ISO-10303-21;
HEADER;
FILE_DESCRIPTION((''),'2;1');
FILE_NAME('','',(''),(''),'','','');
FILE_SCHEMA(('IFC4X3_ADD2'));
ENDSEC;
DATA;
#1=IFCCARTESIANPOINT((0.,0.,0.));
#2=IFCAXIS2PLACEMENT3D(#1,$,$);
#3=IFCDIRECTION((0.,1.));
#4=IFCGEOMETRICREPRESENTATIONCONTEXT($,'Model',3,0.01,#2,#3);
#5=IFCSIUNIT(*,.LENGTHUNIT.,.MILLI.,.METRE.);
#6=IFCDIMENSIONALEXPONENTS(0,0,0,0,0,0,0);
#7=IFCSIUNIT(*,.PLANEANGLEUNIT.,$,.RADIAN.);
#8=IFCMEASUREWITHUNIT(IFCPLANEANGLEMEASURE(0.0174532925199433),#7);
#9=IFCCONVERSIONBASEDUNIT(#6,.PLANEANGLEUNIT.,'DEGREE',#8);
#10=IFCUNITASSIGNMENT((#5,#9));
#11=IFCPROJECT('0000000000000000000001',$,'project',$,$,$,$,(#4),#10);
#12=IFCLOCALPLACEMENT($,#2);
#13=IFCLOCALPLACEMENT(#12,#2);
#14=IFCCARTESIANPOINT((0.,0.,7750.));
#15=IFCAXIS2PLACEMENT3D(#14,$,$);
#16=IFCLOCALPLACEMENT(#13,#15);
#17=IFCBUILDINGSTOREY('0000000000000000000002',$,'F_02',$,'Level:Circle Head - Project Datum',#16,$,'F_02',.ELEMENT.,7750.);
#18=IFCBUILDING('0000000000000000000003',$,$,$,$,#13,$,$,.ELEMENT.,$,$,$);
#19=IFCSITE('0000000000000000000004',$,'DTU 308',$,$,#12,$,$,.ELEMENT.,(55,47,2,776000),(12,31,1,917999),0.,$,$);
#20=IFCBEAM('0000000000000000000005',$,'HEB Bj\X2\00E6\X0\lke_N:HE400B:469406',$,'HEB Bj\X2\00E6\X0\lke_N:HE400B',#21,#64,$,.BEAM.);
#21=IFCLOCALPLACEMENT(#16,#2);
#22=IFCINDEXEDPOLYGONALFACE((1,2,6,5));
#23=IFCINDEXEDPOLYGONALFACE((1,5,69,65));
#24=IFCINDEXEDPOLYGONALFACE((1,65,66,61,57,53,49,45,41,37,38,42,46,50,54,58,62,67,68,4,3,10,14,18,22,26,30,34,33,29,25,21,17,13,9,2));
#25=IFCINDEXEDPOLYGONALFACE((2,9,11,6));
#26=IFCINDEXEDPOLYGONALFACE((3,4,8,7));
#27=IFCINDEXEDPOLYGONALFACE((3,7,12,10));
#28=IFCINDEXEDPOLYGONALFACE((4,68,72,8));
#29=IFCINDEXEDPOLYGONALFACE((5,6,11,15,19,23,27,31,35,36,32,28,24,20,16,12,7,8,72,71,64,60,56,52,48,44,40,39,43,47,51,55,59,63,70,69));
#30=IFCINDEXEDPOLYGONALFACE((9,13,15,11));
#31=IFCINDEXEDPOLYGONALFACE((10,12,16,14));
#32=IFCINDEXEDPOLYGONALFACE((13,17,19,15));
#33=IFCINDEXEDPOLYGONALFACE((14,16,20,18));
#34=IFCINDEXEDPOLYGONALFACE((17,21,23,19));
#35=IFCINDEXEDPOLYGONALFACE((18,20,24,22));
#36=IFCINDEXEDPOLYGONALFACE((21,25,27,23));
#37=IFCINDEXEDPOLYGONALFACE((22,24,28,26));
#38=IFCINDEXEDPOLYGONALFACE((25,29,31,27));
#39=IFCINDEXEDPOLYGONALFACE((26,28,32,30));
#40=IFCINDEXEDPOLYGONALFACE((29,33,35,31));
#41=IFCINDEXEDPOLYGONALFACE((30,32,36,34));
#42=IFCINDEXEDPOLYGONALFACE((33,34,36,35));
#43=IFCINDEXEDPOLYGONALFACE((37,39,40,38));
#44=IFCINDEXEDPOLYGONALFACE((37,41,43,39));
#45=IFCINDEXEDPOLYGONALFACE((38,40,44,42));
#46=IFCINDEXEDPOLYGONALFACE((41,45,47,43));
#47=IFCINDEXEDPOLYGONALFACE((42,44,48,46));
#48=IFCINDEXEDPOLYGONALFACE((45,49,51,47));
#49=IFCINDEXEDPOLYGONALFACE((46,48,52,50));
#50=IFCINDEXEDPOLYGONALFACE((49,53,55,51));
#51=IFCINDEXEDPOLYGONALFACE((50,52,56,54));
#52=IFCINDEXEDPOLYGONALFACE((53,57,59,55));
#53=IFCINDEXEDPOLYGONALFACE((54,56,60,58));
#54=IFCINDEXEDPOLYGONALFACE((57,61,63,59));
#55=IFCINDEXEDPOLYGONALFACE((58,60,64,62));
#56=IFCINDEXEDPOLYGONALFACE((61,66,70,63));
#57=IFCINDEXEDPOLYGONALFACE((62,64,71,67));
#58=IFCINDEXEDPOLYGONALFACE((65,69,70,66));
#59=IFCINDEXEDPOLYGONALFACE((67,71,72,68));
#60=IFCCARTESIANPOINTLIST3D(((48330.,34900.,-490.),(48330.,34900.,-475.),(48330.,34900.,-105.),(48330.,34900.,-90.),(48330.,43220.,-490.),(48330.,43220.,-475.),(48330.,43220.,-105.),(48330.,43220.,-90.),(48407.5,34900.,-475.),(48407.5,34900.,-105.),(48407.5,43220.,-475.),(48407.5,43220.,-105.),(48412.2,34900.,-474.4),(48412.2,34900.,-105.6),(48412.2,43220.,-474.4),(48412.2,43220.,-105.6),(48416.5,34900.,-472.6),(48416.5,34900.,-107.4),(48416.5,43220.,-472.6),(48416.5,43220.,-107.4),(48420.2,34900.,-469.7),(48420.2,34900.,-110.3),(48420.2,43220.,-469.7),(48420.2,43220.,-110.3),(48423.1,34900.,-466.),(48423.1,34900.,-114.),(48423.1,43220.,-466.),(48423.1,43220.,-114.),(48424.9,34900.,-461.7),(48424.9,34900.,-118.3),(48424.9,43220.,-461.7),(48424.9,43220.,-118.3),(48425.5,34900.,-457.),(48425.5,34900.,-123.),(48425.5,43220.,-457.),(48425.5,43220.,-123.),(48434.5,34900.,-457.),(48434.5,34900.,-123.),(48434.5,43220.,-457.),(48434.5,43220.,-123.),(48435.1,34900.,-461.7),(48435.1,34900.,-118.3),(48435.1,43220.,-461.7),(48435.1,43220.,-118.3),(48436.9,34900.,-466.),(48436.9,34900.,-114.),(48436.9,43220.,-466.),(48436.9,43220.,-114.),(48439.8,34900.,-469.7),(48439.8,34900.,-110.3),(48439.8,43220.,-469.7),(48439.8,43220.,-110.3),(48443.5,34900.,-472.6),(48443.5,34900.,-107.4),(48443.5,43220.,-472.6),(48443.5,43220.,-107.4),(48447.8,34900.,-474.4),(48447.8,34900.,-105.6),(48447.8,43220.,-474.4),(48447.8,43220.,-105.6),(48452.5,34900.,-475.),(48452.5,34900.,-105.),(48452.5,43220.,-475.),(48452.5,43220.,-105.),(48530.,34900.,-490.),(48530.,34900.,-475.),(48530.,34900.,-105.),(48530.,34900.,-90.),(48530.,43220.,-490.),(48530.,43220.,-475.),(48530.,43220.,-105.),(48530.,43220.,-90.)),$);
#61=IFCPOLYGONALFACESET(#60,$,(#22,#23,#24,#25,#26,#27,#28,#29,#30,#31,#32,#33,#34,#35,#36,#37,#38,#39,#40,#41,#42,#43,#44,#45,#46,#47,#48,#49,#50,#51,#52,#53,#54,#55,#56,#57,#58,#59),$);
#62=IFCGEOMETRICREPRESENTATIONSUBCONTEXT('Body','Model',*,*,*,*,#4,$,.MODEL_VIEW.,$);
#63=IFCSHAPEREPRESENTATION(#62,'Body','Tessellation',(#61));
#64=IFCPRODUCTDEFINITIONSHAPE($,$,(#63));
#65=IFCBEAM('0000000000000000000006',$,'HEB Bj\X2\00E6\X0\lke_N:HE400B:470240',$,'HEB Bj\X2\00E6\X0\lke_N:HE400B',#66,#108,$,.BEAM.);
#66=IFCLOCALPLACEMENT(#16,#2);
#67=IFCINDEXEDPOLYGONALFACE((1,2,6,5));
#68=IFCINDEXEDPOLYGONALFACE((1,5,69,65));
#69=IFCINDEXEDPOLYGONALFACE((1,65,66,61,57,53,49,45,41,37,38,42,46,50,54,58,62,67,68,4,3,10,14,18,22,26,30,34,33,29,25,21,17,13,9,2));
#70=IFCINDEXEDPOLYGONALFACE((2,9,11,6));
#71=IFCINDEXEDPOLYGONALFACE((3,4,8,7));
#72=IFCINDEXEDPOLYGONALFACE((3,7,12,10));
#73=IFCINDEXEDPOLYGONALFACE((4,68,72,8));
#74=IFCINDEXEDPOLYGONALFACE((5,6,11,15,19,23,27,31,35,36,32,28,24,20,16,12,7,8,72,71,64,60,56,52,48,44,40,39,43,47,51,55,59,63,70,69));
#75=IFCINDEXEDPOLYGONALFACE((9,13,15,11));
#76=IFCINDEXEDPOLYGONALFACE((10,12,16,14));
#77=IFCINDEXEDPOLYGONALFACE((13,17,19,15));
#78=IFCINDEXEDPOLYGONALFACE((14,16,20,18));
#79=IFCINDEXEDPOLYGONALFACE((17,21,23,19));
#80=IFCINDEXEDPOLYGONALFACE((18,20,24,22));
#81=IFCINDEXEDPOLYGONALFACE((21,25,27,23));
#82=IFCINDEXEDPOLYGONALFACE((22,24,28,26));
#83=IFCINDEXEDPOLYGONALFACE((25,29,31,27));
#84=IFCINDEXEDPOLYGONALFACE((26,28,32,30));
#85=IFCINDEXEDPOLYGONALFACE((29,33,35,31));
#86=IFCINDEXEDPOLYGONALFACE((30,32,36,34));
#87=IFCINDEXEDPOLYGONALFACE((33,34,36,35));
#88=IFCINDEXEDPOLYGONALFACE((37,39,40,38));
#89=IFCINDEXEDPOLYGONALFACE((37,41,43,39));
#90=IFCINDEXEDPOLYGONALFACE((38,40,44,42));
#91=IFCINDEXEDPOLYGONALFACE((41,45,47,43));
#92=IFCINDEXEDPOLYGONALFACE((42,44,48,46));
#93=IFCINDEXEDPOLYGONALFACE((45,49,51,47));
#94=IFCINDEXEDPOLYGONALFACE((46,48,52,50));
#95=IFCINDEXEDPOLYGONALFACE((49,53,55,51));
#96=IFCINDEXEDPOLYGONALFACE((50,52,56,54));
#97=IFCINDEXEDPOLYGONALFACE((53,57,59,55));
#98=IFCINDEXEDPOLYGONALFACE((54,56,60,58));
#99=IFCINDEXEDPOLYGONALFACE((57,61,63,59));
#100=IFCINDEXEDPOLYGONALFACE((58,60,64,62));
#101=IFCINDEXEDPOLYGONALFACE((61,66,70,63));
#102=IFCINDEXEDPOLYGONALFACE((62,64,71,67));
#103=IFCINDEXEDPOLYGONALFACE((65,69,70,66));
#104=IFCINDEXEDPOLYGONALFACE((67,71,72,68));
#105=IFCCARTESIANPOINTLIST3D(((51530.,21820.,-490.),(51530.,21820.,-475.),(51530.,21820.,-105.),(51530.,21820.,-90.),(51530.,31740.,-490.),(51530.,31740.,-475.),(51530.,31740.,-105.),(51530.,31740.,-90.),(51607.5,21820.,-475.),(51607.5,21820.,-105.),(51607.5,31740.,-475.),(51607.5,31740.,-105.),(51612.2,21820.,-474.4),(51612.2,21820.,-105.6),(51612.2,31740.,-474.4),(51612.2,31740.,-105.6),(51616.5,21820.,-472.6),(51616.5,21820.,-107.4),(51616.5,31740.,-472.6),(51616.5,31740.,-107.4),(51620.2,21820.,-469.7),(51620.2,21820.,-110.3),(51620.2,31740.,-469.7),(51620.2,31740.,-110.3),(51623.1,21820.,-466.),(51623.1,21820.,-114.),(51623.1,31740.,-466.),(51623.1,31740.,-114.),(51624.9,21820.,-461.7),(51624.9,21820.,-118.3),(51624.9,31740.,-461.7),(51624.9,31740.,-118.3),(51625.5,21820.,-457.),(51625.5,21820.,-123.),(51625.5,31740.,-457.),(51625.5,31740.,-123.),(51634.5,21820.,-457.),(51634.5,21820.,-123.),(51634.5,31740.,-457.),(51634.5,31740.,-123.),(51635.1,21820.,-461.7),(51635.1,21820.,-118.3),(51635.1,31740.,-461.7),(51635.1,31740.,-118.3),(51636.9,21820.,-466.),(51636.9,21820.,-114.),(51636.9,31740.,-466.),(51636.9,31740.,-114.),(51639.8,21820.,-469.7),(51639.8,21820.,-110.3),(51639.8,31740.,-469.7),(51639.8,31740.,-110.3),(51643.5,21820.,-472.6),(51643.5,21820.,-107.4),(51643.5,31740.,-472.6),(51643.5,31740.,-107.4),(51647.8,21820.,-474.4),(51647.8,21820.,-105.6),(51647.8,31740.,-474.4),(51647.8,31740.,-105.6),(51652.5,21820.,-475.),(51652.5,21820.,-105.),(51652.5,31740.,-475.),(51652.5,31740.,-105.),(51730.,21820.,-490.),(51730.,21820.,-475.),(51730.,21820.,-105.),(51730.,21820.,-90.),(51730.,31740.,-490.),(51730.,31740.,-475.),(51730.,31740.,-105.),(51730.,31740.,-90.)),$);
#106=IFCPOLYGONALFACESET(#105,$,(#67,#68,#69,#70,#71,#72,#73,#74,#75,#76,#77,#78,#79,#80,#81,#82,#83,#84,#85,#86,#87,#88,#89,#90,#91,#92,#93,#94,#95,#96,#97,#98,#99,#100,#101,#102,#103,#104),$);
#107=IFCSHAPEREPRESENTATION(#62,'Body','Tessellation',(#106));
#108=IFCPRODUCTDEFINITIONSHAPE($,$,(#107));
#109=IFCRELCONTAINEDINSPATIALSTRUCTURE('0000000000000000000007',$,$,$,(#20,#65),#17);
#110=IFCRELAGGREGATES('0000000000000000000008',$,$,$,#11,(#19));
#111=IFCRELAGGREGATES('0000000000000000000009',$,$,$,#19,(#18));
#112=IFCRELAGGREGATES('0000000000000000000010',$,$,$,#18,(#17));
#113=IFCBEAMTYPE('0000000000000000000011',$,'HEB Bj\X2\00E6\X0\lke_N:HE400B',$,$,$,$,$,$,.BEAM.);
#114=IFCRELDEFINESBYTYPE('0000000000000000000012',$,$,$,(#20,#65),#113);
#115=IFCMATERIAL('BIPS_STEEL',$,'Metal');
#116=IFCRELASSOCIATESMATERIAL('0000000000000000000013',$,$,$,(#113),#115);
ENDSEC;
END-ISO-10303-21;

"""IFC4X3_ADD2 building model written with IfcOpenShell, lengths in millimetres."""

from ifc_helpers import new_model, entity, si_unit, converted_unit, direction, frame, frame_2d, origin, place, context, subcontext, project, spatial, polyline, circle_curve, parameter, trimmed, segment, composite_curve, outline, extrude, source, transform, mapped, material, material_profile, profile_set, type_object, element, save


model = new_model("IFC4X3_ADD2")

# Units and contexts
model_context = context("Model", 3, precision=0.01, world=origin(), true_north=direction((0.0, 1.0)))
body_context = subcontext(model_context, "Body", "Model", "MODEL_VIEW")
ifc_project = project(units=[si_unit("LENGTHUNIT", "METRE", prefix="MILLI"), converted_unit("PLANEANGLEUNIT", "DEGREE", entity("IfcPlaneAngleMeasure", 0.0174532925199433), si_unit("PLANEANGLEUNIT", "RADIAN"), dimensions=[0, 0, 0, 0, 0, 0, 0])], contexts=[model_context])

# Site, building, storey
site_placement = place(None, origin())
site = spatial("IfcSite", under=ifc_project, at=site_placement, Name="DTU 308", CompositionType="ELEMENT", RefLatitude=(55, 47, 2, 776000), RefLongitude=(12, 31, 1, 917999), RefElevation=0.0)
building_placement = place(site_placement, origin())
building = spatial("IfcBuilding", under=site, at=building_placement, CompositionType="ELEMENT")
storey_placement = place(building_placement, frame((0.0, 0.0, 7750.0)))
storey = spatial("IfcBuildingStorey", under=building, at=storey_placement, Name="F_02", ObjectType="Level:Circle Head - Project Datum", LongName="F_02", CompositionType="ELEMENT", Elevation=7750.0)

# Shared definitions
ifc_material = material(Name="BIPS_STEEL", Category="Metal")

# Beams
ifc_material_profile_1 = material_profile(ifc_material, outline(composite_curve([segment(polyline([(-100.0, -185.0), (-100.0, -200.0)]), True, "CONTINUOUS"), segment(polyline([(-100.0, -200.0), (100.0, -200.0)]), True, "CONTINUOUS"), segment(polyline([(100.0, -200.0), (100.0, -185.0)]), True, "CONTINUOUS"), segment(polyline([(100.0, -185.0), (22.5, -185.0)]), True, "CONTINUOUS"), segment(trimmed(circle_curve(frame_2d((22.5, -167.0), x_axis=(1.0, 0.0)), 18.0), [parameter(180.0)], [parameter(270.0)], True, "PARAMETER"), False, "CONTINUOUS"), segment(polyline([(4.5, -167.0), (4.5, 167.0)]), True, "CONTINUOUS"), segment(trimmed(circle_curve(frame_2d((22.5, 167.0), x_axis=(1.0, 0.0)), 18.0), [parameter(90.0)], [parameter(180.0)], True, "PARAMETER"), False, "CONTINUOUS"), segment(polyline([(22.5, 185.0), (100.0, 185.0)]), True, "CONTINUOUS"), segment(polyline([(100.0, 185.0), (100.0, 200.0)]), True, "CONTINUOUS"), segment(polyline([(100.0, 200.0), (-100.0, 200.0)]), True, "CONTINUOUS"), segment(polyline([(-100.0, 200.0), (-100.0, 185.0)]), True, "CONTINUOUS"), segment(polyline([(-100.0, 185.0), (-22.5, 185.0)]), True, "CONTINUOUS"), segment(trimmed(circle_curve(frame_2d((-22.5, 167.0), x_axis=(1.0, 0.0)), 18.0), [parameter(360.0)], [parameter(90.0)], True, "PARAMETER"), False, "CONTINUOUS"), segment(polyline([(-4.5, 167.0), (-4.5, -167.0)]), True, "CONTINUOUS"), segment(trimmed(circle_curve(frame_2d((-22.5, -167.0), x_axis=(1.0, 0.0)), 18.0), [parameter(270.0)], [parameter(360.0)], True, "PARAMETER"), False, "CONTINUOUS"), segment(polyline([(-22.5, -185.0), (-100.0, -185.0)]), True, "CONTINUOUS")], self_intersect=False)), Name="HE400B")
ifc_profile_set_1 = profile_set([ifc_material_profile_1], Name="HE400B")
beam_type_1 = type_object("IfcBeamType", Name="HEB Bjælke_N:HE400B", PredefinedType="BEAM", material=ifc_profile_set_1)
shared_shape_1 = source(origin(), body_context, "Body", "SweptSolid", [
    extrude(outline(composite_curve([segment(polyline([(-100.0, -185.0), (-100.0, -200.0)]), True, "CONTINUOUS"), segment(polyline([(-100.0, -200.0), (100.0, -200.0)]), True, "CONTINUOUS"), segment(polyline([(100.0, -200.0), (100.0, -185.0)]), True, "CONTINUOUS"), segment(polyline([(100.0, -185.0), (22.5, -185.0)]), True, "CONTINUOUS"), segment(trimmed(circle_curve(frame_2d((22.5, -167.0), x_axis=(1.0, 0.0)), 18.0), [parameter(180.0)], [parameter(270.0)], True, "PARAMETER"), False, "CONTINUOUS"), segment(polyline([(4.5, -167.0), (4.5, 167.0)]), True, "CONTINUOUS"), segment(trimmed(circle_curve(frame_2d((22.5, 167.0), x_axis=(1.0, 0.0)), 18.0), [parameter(90.0)], [parameter(180.0)], True, "PARAMETER"), False, "CONTINUOUS"), segment(polyline([(22.5, 185.0), (100.0, 185.0)]), True, "CONTINUOUS"), segment(polyline([(100.0, 185.0), (100.0, 200.0)]), True, "CONTINUOUS"), segment(polyline([(100.0, 200.0), (-100.0, 200.0)]), True, "CONTINUOUS"), segment(polyline([(-100.0, 200.0), (-100.0, 185.0)]), True, "CONTINUOUS"), segment(polyline([(-100.0, 185.0), (-22.5, 185.0)]), True, "CONTINUOUS"), segment(trimmed(circle_curve(frame_2d((-22.5, 167.0), x_axis=(1.0, 0.0)), 18.0), [parameter(360.0)], [parameter(90.0)], True, "PARAMETER"), False, "CONTINUOUS"), segment(polyline([(-4.5, 167.0), (-4.5, -167.0)]), True, "CONTINUOUS"), segment(trimmed(circle_curve(frame_2d((-22.5, -167.0), x_axis=(1.0, 0.0)), 18.0), [parameter(270.0)], [parameter(360.0)], True, "PARAMETER"), False, "CONTINUOUS"), segment(polyline([(-22.5, -185.0), (-100.0, -185.0)]), True, "CONTINUOUS")], self_intersect=False)), frame((-6461.4, 0.0, 0.0), z_axis=(-1.0, 0.0, 0.0), x_axis=(0.0, -1.0, 0.0)), (0.0, 0.0, -1.0), 8320.0),
])
beam_1_placement = place(storey_placement, frame((48430.0, 36758.6, -290.0), z_axis=(0.0, 0.0, 1.0), x_axis=(0.0, -1.0, 0.0)))
element("IfcBeam", 1, at=beam_1_placement, inside=storey, type_object=beam_type_1, Name="HEB Bjælke_N:HE400B:469406", ObjectType="HEB Bjælke_N:HE400B", PredefinedType="BEAM", context=body_context, shape_type="MappedRepresentation", body=[
    mapped(shared_shape_1, transform((0.0, 0.0, 0.0), scale=1.0)),
])
shared_shape_2 = source(origin(), body_context, "Body", "SweptSolid", [
    extrude(outline(composite_curve([segment(polyline([(-100.0, -185.0), (-100.0, -200.0)]), True, "CONTINUOUS"), segment(polyline([(-100.0, -200.0), (100.0, -200.0)]), True, "CONTINUOUS"), segment(polyline([(100.0, -200.0), (100.0, -185.0)]), True, "CONTINUOUS"), segment(polyline([(100.0, -185.0), (22.5, -185.0)]), True, "CONTINUOUS"), segment(trimmed(circle_curve(frame_2d((22.5, -167.0), x_axis=(1.0, 0.0)), 18.0), [parameter(180.0)], [parameter(270.0)], True, "PARAMETER"), False, "CONTINUOUS"), segment(polyline([(4.5, -167.0), (4.5, 167.0)]), True, "CONTINUOUS"), segment(trimmed(circle_curve(frame_2d((22.5, 167.0), x_axis=(1.0, 0.0)), 18.0), [parameter(90.0)], [parameter(180.0)], True, "PARAMETER"), False, "CONTINUOUS"), segment(polyline([(22.5, 185.0), (100.0, 185.0)]), True, "CONTINUOUS"), segment(polyline([(100.0, 185.0), (100.0, 200.0)]), True, "CONTINUOUS"), segment(polyline([(100.0, 200.0), (-100.0, 200.0)]), True, "CONTINUOUS"), segment(polyline([(-100.0, 200.0), (-100.0, 185.0)]), True, "CONTINUOUS"), segment(polyline([(-100.0, 185.0), (-22.5, 185.0)]), True, "CONTINUOUS"), segment(trimmed(circle_curve(frame_2d((-22.5, 167.0), x_axis=(1.0, 0.0)), 18.0), [parameter(360.0)], [parameter(90.0)], True, "PARAMETER"), False, "CONTINUOUS"), segment(polyline([(-4.5, 167.0), (-4.5, -167.0)]), True, "CONTINUOUS"), segment(trimmed(circle_curve(frame_2d((-22.5, -167.0), x_axis=(1.0, 0.0)), 18.0), [parameter(270.0)], [parameter(360.0)], True, "PARAMETER"), False, "CONTINUOUS"), segment(polyline([(-22.5, -185.0), (-100.0, -185.0)]), True, "CONTINUOUS")], self_intersect=False)), frame((-1740.0, 0.0, 0.0), z_axis=(-1.0, 0.0, 0.0), x_axis=(0.0, -1.0, 0.0)), (0.0, 0.0, -1.0), 9920.0),
])
beam_2_placement = place(storey_placement, frame((51630.0, 30000.0, -290.0), z_axis=(0.0, 0.0, 1.0), x_axis=(0.0, -1.0, 0.0)))
element("IfcBeam", 2, at=beam_2_placement, inside=storey, type_object=beam_type_1, Name="HEB Bjælke_N:HE400B:470240", ObjectType="HEB Bjælke_N:HE400B", PredefinedType="BEAM", context=body_context, shape_type="MappedRepresentation", body=[
    mapped(shared_shape_2, transform((0.0, 0.0, 0.0), scale=1.0)),
])

save(model, "model.ifc")
